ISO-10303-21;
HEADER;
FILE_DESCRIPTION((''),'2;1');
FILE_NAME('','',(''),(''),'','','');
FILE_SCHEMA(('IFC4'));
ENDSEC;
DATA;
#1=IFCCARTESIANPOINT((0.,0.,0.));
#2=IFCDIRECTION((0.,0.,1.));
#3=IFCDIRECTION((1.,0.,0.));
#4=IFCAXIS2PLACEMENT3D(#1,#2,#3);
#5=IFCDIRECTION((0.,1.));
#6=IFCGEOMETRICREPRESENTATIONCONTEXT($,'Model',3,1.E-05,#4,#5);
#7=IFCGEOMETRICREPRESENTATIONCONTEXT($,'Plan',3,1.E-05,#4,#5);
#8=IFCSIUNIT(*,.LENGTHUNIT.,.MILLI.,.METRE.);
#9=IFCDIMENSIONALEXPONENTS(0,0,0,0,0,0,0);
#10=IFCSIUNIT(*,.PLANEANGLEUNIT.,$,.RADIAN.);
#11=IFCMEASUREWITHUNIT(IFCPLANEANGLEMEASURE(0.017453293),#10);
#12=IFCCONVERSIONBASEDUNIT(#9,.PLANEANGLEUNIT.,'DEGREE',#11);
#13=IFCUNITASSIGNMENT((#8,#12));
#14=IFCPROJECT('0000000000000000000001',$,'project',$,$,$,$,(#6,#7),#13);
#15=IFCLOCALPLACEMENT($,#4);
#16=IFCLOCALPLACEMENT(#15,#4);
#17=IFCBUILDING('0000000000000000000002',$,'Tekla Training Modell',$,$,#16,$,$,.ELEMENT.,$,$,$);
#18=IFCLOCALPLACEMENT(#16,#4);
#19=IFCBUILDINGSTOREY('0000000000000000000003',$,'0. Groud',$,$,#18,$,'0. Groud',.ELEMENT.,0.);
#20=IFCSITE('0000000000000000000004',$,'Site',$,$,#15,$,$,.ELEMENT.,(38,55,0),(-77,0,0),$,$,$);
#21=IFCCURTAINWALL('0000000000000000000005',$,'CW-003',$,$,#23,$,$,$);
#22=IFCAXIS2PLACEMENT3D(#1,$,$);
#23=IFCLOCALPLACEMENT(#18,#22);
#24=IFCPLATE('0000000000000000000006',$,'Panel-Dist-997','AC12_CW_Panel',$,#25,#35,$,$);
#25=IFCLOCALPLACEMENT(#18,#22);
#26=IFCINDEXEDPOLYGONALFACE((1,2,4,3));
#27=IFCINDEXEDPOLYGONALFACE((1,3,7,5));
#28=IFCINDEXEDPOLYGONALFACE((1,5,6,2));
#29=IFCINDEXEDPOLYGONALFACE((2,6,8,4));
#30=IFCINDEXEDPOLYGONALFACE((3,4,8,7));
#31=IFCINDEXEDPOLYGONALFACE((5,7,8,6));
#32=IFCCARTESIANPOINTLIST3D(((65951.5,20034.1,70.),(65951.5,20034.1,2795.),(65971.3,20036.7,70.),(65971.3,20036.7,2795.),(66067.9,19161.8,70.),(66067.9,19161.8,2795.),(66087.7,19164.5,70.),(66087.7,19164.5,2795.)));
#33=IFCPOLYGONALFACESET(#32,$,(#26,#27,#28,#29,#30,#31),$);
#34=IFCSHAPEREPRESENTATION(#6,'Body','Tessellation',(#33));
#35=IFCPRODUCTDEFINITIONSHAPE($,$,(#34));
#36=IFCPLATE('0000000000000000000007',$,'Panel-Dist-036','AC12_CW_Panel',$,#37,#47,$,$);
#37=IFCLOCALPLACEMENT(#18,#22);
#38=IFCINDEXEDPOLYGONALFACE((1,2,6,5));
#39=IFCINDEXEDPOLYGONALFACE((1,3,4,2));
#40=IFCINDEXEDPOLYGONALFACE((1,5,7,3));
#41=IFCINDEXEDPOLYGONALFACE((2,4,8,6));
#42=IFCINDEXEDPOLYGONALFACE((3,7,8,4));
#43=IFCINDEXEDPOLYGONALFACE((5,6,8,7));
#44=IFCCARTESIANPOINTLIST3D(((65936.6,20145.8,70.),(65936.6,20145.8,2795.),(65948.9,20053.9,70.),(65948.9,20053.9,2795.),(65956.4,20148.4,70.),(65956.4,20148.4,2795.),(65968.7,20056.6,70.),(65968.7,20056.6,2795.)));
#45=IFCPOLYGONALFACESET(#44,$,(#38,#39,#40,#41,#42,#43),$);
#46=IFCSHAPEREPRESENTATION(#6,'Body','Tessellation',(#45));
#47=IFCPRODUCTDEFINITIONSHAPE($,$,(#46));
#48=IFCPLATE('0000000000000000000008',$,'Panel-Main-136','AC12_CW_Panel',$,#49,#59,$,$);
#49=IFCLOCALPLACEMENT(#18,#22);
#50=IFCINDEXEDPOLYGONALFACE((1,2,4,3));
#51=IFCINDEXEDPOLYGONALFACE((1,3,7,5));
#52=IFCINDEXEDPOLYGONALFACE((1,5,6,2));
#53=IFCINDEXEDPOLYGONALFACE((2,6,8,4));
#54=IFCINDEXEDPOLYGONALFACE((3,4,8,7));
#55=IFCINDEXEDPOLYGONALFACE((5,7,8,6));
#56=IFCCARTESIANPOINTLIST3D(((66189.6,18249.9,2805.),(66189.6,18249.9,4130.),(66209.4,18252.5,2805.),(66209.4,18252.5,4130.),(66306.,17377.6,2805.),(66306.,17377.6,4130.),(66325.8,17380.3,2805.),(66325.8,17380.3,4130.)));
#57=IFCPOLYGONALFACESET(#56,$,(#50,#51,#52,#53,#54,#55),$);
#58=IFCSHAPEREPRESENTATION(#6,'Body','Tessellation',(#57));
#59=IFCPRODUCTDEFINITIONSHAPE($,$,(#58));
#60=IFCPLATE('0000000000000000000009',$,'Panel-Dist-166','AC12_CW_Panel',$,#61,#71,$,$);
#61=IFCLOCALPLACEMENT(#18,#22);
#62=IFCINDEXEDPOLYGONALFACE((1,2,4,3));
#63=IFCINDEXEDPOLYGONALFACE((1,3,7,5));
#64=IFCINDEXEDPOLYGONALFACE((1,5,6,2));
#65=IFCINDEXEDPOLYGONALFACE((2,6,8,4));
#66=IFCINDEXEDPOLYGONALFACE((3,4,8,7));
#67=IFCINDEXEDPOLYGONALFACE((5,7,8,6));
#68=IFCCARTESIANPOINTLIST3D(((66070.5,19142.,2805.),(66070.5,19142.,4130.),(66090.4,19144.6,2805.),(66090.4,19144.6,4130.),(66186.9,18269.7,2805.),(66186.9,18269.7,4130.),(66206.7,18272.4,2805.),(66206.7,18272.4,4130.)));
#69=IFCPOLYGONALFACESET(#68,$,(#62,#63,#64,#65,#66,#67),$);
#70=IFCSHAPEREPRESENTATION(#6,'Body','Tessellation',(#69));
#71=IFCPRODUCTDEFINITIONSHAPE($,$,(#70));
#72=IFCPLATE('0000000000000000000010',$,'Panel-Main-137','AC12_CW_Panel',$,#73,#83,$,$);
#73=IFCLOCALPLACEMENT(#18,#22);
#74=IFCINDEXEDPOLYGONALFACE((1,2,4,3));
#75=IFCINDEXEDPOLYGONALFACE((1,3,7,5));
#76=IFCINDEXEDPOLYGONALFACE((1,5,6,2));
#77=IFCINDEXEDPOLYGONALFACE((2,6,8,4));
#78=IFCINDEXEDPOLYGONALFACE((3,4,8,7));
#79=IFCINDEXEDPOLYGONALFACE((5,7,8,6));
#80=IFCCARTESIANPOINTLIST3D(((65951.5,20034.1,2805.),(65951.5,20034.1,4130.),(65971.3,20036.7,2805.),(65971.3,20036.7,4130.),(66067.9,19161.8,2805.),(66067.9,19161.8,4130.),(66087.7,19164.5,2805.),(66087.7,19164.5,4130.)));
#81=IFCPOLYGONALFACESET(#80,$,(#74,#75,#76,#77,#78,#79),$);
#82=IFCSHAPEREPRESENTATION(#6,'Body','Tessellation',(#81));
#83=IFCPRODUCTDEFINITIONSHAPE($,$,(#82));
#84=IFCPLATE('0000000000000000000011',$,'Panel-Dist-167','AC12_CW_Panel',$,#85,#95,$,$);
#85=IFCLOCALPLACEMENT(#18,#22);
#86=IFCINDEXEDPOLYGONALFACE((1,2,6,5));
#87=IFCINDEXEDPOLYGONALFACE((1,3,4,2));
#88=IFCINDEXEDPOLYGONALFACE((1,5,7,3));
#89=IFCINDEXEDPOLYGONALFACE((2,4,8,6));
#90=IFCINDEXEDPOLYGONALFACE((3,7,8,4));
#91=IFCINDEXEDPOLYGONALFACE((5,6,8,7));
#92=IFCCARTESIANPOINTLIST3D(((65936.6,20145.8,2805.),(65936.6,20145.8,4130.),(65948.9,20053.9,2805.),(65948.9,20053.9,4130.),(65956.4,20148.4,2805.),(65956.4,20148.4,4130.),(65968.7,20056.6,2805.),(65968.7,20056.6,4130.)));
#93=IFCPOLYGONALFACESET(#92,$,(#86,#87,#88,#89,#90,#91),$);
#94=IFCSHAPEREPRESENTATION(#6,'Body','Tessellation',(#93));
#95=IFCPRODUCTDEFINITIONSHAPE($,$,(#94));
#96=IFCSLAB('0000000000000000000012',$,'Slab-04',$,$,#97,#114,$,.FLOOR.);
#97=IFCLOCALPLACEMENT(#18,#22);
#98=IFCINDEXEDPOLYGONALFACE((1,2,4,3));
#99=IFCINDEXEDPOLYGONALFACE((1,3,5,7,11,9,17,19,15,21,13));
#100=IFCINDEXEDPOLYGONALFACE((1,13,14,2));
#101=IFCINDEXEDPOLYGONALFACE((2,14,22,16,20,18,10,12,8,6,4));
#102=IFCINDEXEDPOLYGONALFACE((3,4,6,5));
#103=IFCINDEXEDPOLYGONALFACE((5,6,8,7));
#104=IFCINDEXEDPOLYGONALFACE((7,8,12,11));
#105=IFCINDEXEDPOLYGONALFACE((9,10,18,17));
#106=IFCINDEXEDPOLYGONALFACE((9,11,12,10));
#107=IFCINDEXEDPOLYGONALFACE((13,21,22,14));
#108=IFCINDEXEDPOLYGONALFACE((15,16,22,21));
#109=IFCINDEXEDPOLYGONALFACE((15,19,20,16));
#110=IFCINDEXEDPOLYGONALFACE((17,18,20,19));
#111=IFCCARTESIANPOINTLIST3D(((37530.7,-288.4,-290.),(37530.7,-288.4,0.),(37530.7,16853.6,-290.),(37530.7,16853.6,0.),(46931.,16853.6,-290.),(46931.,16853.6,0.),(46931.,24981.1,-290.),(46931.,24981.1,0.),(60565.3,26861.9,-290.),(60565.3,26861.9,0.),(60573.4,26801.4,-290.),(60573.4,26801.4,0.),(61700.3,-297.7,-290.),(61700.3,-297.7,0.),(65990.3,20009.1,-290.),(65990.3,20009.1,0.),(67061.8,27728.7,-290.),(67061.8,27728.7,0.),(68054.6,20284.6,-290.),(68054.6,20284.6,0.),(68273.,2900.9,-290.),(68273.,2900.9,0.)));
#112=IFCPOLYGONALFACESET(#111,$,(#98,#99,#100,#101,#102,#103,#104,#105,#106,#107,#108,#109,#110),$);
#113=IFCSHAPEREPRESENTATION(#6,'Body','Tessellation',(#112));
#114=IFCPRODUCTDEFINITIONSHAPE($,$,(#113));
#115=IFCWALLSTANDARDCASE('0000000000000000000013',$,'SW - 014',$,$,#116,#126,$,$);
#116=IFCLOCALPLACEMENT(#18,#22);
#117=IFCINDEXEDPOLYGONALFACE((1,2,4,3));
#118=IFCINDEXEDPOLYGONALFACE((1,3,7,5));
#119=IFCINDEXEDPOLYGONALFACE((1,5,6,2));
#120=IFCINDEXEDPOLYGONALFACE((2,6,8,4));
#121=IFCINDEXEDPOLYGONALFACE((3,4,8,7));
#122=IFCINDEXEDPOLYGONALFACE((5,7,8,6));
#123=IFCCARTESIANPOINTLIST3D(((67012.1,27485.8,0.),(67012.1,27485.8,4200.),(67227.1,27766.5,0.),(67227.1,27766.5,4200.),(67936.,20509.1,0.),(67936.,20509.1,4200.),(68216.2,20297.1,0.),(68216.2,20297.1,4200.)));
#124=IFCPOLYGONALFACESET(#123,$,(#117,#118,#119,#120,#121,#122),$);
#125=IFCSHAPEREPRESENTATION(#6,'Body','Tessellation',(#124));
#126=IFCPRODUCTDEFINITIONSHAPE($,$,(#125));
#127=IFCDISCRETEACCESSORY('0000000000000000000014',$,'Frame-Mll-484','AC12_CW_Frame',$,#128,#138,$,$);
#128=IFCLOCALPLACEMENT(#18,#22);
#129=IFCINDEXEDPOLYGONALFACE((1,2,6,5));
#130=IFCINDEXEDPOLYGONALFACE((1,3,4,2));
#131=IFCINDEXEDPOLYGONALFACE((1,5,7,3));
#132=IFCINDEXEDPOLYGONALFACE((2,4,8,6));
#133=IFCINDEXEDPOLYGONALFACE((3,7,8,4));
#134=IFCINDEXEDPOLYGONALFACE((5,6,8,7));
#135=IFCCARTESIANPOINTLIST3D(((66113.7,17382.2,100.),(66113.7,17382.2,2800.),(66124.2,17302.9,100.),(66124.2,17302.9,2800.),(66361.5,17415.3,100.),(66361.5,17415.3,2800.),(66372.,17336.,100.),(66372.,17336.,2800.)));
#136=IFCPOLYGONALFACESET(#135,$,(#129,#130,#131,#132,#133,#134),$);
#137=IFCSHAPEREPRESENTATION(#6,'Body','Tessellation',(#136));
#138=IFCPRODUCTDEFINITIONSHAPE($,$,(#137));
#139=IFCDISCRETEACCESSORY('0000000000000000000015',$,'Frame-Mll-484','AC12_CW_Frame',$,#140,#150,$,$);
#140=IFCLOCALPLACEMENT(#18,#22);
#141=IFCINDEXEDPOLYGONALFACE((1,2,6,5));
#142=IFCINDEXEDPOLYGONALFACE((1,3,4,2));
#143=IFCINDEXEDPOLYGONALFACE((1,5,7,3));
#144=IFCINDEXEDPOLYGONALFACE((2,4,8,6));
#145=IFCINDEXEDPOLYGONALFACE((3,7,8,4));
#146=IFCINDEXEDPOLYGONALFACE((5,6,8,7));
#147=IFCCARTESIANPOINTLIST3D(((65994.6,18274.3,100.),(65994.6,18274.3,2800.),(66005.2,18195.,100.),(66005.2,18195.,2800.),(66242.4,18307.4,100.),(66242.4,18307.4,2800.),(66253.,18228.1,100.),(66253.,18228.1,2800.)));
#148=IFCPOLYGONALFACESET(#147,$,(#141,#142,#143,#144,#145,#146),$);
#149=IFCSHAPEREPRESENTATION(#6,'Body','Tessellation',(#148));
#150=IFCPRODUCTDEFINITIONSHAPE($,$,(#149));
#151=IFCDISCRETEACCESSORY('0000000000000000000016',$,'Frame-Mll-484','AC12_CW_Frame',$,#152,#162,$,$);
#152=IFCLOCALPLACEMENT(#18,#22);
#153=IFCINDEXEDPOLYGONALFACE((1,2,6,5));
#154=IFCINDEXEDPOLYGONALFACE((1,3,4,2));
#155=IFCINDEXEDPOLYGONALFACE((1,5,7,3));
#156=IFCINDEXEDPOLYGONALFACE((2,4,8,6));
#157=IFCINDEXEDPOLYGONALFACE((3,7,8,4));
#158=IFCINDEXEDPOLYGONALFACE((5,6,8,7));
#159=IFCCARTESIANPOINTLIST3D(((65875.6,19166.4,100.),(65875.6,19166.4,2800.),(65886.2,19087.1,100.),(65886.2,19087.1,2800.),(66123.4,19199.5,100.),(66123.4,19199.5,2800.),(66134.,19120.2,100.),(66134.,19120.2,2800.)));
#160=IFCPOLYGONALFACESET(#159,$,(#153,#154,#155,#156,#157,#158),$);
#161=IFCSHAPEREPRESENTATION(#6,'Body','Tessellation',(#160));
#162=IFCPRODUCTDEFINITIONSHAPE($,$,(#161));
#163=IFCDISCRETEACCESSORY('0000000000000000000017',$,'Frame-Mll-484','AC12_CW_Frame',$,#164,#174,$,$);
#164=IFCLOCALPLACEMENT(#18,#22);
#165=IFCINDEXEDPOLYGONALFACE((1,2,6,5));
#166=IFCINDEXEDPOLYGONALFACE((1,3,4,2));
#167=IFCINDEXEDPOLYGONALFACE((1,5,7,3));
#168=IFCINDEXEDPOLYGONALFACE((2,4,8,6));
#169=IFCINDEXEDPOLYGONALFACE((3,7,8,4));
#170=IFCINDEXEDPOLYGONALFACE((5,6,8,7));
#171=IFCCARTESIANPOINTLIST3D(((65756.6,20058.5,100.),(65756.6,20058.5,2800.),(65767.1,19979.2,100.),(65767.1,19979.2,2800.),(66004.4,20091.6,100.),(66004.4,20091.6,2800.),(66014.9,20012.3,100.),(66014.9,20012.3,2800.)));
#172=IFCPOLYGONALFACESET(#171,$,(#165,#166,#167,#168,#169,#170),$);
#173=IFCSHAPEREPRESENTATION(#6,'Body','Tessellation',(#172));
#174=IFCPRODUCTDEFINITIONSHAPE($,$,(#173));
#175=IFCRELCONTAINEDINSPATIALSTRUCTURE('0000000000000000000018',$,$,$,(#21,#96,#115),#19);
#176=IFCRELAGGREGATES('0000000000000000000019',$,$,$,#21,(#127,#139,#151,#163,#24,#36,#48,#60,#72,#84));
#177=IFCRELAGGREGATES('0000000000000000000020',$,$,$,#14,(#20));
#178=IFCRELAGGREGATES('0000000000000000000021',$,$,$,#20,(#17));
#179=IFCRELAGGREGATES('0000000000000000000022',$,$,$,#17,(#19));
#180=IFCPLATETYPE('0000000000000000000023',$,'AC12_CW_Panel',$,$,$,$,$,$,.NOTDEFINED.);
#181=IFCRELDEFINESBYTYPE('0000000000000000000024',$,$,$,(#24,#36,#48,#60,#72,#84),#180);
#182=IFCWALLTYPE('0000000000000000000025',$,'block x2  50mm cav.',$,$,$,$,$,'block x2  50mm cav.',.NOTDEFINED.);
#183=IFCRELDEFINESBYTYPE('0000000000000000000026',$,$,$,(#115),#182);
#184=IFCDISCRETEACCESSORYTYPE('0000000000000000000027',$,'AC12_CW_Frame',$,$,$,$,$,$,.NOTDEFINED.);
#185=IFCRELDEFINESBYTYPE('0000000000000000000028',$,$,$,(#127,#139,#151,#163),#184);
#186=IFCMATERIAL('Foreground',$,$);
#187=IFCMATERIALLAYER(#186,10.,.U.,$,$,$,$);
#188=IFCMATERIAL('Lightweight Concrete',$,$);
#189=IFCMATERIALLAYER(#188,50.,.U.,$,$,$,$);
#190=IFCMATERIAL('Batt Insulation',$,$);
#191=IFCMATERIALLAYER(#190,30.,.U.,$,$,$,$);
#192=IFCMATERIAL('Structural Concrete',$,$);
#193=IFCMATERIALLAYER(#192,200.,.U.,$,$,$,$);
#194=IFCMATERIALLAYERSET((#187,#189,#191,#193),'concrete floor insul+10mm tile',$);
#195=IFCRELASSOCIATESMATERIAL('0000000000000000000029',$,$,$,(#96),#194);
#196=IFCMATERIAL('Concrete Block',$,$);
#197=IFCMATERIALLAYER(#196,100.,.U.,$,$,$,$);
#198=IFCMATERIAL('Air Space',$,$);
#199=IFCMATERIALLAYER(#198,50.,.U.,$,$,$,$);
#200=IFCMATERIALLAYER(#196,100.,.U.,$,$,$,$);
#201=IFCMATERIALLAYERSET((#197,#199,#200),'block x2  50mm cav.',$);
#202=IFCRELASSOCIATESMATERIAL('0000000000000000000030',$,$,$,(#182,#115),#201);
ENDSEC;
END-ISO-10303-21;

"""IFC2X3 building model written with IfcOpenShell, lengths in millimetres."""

from ifc_helpers import new_model, entity, si_unit, converted_unit, direction, frame, origin_with_axes, place, context, project, spatial, polyline, outline, extrude, source, transform, mapped, material, layer, layer_set, layer_usage, type_object, element, aggregate, save


model = new_model("IFC2X3")

# Units and contexts
model_context = context("Model", 3, precision=1e-05, world=origin_with_axes(), true_north=direction((0.0, 1.0)))
plan_context = context("Plan", 3, precision=1e-05, world=origin_with_axes(), true_north=direction((0.0, 1.0)))
ifc_project = project(units=[si_unit("LENGTHUNIT", "METRE", prefix="MILLI"), converted_unit("PLANEANGLEUNIT", "DEGREE", entity("IfcPlaneAngleMeasure", 0.017453293), si_unit("PLANEANGLEUNIT", "RADIAN"), dimensions=[0, 0, 0, 0, 0, 0, 0])], contexts=[model_context, plan_context])

# Site, building, storey
site_placement = place(None, origin_with_axes())
site = spatial("IfcSite", under=ifc_project, at=site_placement, Name="Site", CompositionType="ELEMENT", RefLatitude=(38, 55, 0), RefLongitude=(-77, 0, 0))
building_placement = place(site_placement, origin_with_axes())
building = spatial("IfcBuilding", under=site, at=building_placement, Name="Tekla Training Modell", CompositionType="ELEMENT")
storey_placement = place(building_placement, origin_with_axes())
storey = spatial("IfcBuildingStorey", under=building, at=storey_placement, Name="0. Groud", LongName="0. Groud", CompositionType="ELEMENT", Elevation=0.0)

# Curtain wall, plates
curtain_wall_placement = place(storey_placement, frame((68221.7, 3095.5, 0.0), z_axis=(0.0, 0.0, 1.0), x_axis=(-0.132257, 0.991216, 0.0)))
curtain_wall = element("IfcCurtainWall", 1, at=curtain_wall_placement, inside=storey, Name="CW-003")
plate_type = type_object("IfcPlateType", Name="AC12_CW_Panel", PredefinedType="NOTDEFINED")
shared_shape_1 = source(origin_with_axes(), model_context, "Body", "SweptSolid", [
    extrude(outline(polyline([(0.0, 0.0), (880.0, 0.0), (880.0, -20.0), (0.0, -20.0), (0.0, 0.0)])), origin_with_axes(), (0.0, 0.0, 1.0), 2725.0),
])
plate_1_placement = place(storey_placement, frame((66067.9, 19161.8, 70.0), z_axis=(0.0, 0.0, 1.0), x_axis=(-0.132257, 0.991216, 0.0)))
plate_1 = element("IfcPlate", 2, at=plate_1_placement, type_object=plate_type, Name="Panel-Dist-997", Description="AC12_CW_Panel", context=model_context, shape_type="MappedRepresentation", body=[
    mapped(shared_shape_1, transform((0.0, 0.0, 0.0), scale=1.0)),
])
shared_shape_2 = source(origin_with_axes(), model_context, "Body", "SweptSolid", [
    extrude(outline(polyline([(0.0, 0.0), (92.7, 0.0), (92.7, -20.0), (0.0, -20.0), (0.0, 0.0)])), origin_with_axes(), (0.0, 0.0, 1.0), 2725.0),
])
plate_2_placement = place(storey_placement, frame((65948.9, 20053.9, 70.0), z_axis=(0.0, 0.0, 1.0), x_axis=(-0.132257, 0.991216, 0.0)))
plate_2 = element("IfcPlate", 3, at=plate_2_placement, type_object=plate_type, Name="Panel-Dist-036", Description="AC12_CW_Panel", context=model_context, shape_type="MappedRepresentation", body=[
    mapped(shared_shape_2, transform((0.0, 0.0, 0.0), scale=1.0)),
])
shared_shape_3 = source(origin_with_axes(), model_context, "Body", "SweptSolid", [
    extrude(outline(polyline([(0.0, 0.0), (880.0, 0.0), (880.0, -20.0), (0.0, -20.0), (0.0, 0.0)])), origin_with_axes(), (0.0, 0.0, 1.0), 1325.0),
])
plate_3_placement = place(storey_placement, frame((66306.0, 17377.6, 2805.0), z_axis=(0.0, 0.0, 1.0), x_axis=(-0.132257, 0.991216, 0.0)))
plate_3 = element("IfcPlate", 4, at=plate_3_placement, type_object=plate_type, Name="Panel-Main-136", Description="AC12_CW_Panel", context=model_context, shape_type="MappedRepresentation", body=[
    mapped(shared_shape_3, transform((0.0, 0.0, 0.0), scale=1.0)),
])
plate_4_placement = place(storey_placement, frame((66186.9, 18269.7, 2805.0), z_axis=(0.0, 0.0, 1.0), x_axis=(-0.132257, 0.991216, 0.0)))
plate_4 = element("IfcPlate", 5, at=plate_4_placement, type_object=plate_type, Name="Panel-Dist-166", Description="AC12_CW_Panel", context=model_context, shape_type="MappedRepresentation", body=[
    mapped(shared_shape_3, transform((0.0, 0.0, 0.0), scale=1.0)),
])
plate_5_placement = place(storey_placement, frame((66067.9, 19161.8, 2805.0), z_axis=(0.0, 0.0, 1.0), x_axis=(-0.132257, 0.991216, 0.0)))
plate_5 = element("IfcPlate", 6, at=plate_5_placement, type_object=plate_type, Name="Panel-Main-137", Description="AC12_CW_Panel", context=model_context, shape_type="MappedRepresentation", body=[
    mapped(shared_shape_3, transform((0.0, 0.0, 0.0), scale=1.0)),
])
shared_shape_4 = source(origin_with_axes(), model_context, "Body", "SweptSolid", [
    extrude(outline(polyline([(0.0, 0.0), (92.7, 0.0), (92.7, -20.0), (0.0, -20.0), (0.0, 0.0)])), origin_with_axes(), (0.0, 0.0, 1.0), 1325.0),
])
plate_6_placement = place(storey_placement, frame((65948.9, 20053.9, 2805.0), z_axis=(0.0, 0.0, 1.0), x_axis=(-0.132257, 0.991216, 0.0)))
plate_6 = element("IfcPlate", 7, at=plate_6_placement, type_object=plate_type, Name="Panel-Dist-167", Description="AC12_CW_Panel", context=model_context, shape_type="MappedRepresentation", body=[
    mapped(shared_shape_4, transform((0.0, 0.0, 0.0), scale=1.0)),
])

# Slab
ifc_material_1 = material(Name="Foreground")
ifc_layer_1 = layer(ifc_material_1, 10.0, ventilated="UNKNOWN")
ifc_material_2 = material(Name="Lightweight Concrete")
ifc_layer_2 = layer(ifc_material_2, 50.0, ventilated="UNKNOWN")
ifc_material_3 = material(Name="Batt Insulation")
ifc_layer_3 = layer(ifc_material_3, 30.0, ventilated="UNKNOWN")
ifc_material_4 = material(Name="Structural Concrete")
ifc_layer_4 = layer(ifc_material_4, 200.0, ventilated="UNKNOWN")
ifc_layer_set_1 = layer_set([ifc_layer_1, ifc_layer_2, ifc_layer_3, ifc_layer_4], Name="concrete floor insul+10mm tile")
ifc_layer_usage_1 = layer_usage(ifc_layer_set_1, "AXIS3", "NEGATIVE", 290.0)
slab_placement = place(storey_placement, frame((67061.8, 27728.7, -290.0), z_axis=(0.0, 0.0, 1.0), x_axis=(-0.991216, -0.132256, 0.0)))
element("IfcSlab", 8, at=slab_placement, inside=storey, material=ifc_layer_usage_1, Name="Slab-04", PredefinedType="FLOOR", context=model_context, shape_type="SweptSolid", body=[
    extrude(outline(polyline([(0.0, 0.0), (6554.0, 0.0), (6554.0, 61.0), (20317.3, 61.0), (21392.2, 8117.1), (30709.9, 6873.9), (32977.0, 23865.3), (9021.0, 27071.1), (2083.0, 24769.8), (2083.0, 7510.0), (0.4, 7510.0), (0.0, 0.0)])), origin_with_axes(), (0.0, 0.0, 1.0), 290.0),
])

# Wall
ifc_material_5 = material(Name="Concrete Block")
ifc_layer_5 = layer(ifc_material_5, 100.0, ventilated="UNKNOWN")
ifc_material_6 = material(Name="Air Space")
ifc_layer_6 = layer(ifc_material_6, 50.0, ventilated="UNKNOWN")
ifc_layer_7 = layer(ifc_material_5, 100.0, ventilated="UNKNOWN")
ifc_layer_set_2 = layer_set([ifc_layer_5, ifc_layer_6, ifc_layer_7], Name="block x2  50mm cav.")
ifc_layer_usage_2 = layer_usage(ifc_layer_set_2, "AXIS2", "NEGATIVE", 0.0)
wall_type = type_object("IfcWallType", Name="block x2  50mm cav.", ElementType="block x2  50mm cav.", PredefinedType="NOTDEFINED", material=ifc_layer_set_2)
wall_placement = place(storey_placement, frame((67936.0, 20509.1, 0.0), z_axis=(0.0, 0.0, 1.0), x_axis=(-0.131283, 0.991345, 0.0)))
element("IfcWallStandardCase", 9, at=wall_placement, inside=storey, type_object=wall_type, material=ifc_layer_usage_2, Name="SW - 014", context=model_context, shape_type="SweptSolid", body=[
    extrude(outline(polyline([(-246.9, -250.0), (7287.7, -250.0), (7037.6, 0.0), (0.0, 0.0), (-246.9, -250.0)])), origin_with_axes(), (0.0, 0.0, 1.0), 4200.0),
])

# Discrete accessories
discrete_accessory_type = type_object("IfcDiscreteAccessoryType", Name="AC12_CW_Frame")
shared_shape_5 = source(origin_with_axes(), model_context, "Body", "SweptSolid", [
    extrude(outline(polyline([(0.0, 0.0), (250.0, 0.0), (250.0, -2700.0), (0.0, -2700.0), (0.0, 0.0)])), origin_with_axes(), (0.0, 0.0, 1.0), 80.0),
])
discrete_accessory_1_placement = place(storey_placement, frame((66124.2, 17302.9, 100.0), z_axis=(-0.132257, 0.991216, 0.0), x_axis=(0.991216, 0.132257, 0.0)))
discrete_accessory_1 = element("IfcDiscreteAccessory", 10, at=discrete_accessory_1_placement, type_object=discrete_accessory_type, Name="Frame-Mll-484", Description="AC12_CW_Frame", context=model_context, shape_type="MappedRepresentation", body=[
    mapped(shared_shape_5, transform((0.0, 0.0, 0.0), scale=1.0)),
])
discrete_accessory_2_placement = place(storey_placement, frame((66005.2, 18195.0, 100.0), z_axis=(-0.132257, 0.991216, 0.0), x_axis=(0.991216, 0.132257, 0.0)))
discrete_accessory_2 = element("IfcDiscreteAccessory", 11, at=discrete_accessory_2_placement, type_object=discrete_accessory_type, Name="Frame-Mll-484", Description="AC12_CW_Frame", context=model_context, shape_type="MappedRepresentation", body=[
    mapped(shared_shape_5, transform((0.0, 0.0, 0.0), scale=1.0)),
])
discrete_accessory_3_placement = place(storey_placement, frame((65886.2, 19087.1, 100.0), z_axis=(-0.132257, 0.991216, 0.0), x_axis=(0.991216, 0.132257, 0.0)))
discrete_accessory_3 = element("IfcDiscreteAccessory", 12, at=discrete_accessory_3_placement, type_object=discrete_accessory_type, Name="Frame-Mll-484", Description="AC12_CW_Frame", context=model_context, shape_type="MappedRepresentation", body=[
    mapped(shared_shape_5, transform((0.0, 0.0, 0.0), scale=1.0)),
])
discrete_accessory_4_placement = place(storey_placement, frame((65767.1, 19979.2, 100.0), z_axis=(-0.132257, 0.991216, 0.0), x_axis=(0.991216, 0.132257, 0.0)))
discrete_accessory_4 = element("IfcDiscreteAccessory", 13, at=discrete_accessory_4_placement, type_object=discrete_accessory_type, Name="Frame-Mll-484", Description="AC12_CW_Frame", context=model_context, shape_type="MappedRepresentation", body=[
    mapped(shared_shape_5, transform((0.0, 0.0, 0.0), scale=1.0)),
])
aggregate(curtain_wall, [discrete_accessory_1, discrete_accessory_2, discrete_accessory_3, discrete_accessory_4, plate_1, plate_2, plate_3, plate_4, plate_5, plate_6])

save(model, "model.ifc")
